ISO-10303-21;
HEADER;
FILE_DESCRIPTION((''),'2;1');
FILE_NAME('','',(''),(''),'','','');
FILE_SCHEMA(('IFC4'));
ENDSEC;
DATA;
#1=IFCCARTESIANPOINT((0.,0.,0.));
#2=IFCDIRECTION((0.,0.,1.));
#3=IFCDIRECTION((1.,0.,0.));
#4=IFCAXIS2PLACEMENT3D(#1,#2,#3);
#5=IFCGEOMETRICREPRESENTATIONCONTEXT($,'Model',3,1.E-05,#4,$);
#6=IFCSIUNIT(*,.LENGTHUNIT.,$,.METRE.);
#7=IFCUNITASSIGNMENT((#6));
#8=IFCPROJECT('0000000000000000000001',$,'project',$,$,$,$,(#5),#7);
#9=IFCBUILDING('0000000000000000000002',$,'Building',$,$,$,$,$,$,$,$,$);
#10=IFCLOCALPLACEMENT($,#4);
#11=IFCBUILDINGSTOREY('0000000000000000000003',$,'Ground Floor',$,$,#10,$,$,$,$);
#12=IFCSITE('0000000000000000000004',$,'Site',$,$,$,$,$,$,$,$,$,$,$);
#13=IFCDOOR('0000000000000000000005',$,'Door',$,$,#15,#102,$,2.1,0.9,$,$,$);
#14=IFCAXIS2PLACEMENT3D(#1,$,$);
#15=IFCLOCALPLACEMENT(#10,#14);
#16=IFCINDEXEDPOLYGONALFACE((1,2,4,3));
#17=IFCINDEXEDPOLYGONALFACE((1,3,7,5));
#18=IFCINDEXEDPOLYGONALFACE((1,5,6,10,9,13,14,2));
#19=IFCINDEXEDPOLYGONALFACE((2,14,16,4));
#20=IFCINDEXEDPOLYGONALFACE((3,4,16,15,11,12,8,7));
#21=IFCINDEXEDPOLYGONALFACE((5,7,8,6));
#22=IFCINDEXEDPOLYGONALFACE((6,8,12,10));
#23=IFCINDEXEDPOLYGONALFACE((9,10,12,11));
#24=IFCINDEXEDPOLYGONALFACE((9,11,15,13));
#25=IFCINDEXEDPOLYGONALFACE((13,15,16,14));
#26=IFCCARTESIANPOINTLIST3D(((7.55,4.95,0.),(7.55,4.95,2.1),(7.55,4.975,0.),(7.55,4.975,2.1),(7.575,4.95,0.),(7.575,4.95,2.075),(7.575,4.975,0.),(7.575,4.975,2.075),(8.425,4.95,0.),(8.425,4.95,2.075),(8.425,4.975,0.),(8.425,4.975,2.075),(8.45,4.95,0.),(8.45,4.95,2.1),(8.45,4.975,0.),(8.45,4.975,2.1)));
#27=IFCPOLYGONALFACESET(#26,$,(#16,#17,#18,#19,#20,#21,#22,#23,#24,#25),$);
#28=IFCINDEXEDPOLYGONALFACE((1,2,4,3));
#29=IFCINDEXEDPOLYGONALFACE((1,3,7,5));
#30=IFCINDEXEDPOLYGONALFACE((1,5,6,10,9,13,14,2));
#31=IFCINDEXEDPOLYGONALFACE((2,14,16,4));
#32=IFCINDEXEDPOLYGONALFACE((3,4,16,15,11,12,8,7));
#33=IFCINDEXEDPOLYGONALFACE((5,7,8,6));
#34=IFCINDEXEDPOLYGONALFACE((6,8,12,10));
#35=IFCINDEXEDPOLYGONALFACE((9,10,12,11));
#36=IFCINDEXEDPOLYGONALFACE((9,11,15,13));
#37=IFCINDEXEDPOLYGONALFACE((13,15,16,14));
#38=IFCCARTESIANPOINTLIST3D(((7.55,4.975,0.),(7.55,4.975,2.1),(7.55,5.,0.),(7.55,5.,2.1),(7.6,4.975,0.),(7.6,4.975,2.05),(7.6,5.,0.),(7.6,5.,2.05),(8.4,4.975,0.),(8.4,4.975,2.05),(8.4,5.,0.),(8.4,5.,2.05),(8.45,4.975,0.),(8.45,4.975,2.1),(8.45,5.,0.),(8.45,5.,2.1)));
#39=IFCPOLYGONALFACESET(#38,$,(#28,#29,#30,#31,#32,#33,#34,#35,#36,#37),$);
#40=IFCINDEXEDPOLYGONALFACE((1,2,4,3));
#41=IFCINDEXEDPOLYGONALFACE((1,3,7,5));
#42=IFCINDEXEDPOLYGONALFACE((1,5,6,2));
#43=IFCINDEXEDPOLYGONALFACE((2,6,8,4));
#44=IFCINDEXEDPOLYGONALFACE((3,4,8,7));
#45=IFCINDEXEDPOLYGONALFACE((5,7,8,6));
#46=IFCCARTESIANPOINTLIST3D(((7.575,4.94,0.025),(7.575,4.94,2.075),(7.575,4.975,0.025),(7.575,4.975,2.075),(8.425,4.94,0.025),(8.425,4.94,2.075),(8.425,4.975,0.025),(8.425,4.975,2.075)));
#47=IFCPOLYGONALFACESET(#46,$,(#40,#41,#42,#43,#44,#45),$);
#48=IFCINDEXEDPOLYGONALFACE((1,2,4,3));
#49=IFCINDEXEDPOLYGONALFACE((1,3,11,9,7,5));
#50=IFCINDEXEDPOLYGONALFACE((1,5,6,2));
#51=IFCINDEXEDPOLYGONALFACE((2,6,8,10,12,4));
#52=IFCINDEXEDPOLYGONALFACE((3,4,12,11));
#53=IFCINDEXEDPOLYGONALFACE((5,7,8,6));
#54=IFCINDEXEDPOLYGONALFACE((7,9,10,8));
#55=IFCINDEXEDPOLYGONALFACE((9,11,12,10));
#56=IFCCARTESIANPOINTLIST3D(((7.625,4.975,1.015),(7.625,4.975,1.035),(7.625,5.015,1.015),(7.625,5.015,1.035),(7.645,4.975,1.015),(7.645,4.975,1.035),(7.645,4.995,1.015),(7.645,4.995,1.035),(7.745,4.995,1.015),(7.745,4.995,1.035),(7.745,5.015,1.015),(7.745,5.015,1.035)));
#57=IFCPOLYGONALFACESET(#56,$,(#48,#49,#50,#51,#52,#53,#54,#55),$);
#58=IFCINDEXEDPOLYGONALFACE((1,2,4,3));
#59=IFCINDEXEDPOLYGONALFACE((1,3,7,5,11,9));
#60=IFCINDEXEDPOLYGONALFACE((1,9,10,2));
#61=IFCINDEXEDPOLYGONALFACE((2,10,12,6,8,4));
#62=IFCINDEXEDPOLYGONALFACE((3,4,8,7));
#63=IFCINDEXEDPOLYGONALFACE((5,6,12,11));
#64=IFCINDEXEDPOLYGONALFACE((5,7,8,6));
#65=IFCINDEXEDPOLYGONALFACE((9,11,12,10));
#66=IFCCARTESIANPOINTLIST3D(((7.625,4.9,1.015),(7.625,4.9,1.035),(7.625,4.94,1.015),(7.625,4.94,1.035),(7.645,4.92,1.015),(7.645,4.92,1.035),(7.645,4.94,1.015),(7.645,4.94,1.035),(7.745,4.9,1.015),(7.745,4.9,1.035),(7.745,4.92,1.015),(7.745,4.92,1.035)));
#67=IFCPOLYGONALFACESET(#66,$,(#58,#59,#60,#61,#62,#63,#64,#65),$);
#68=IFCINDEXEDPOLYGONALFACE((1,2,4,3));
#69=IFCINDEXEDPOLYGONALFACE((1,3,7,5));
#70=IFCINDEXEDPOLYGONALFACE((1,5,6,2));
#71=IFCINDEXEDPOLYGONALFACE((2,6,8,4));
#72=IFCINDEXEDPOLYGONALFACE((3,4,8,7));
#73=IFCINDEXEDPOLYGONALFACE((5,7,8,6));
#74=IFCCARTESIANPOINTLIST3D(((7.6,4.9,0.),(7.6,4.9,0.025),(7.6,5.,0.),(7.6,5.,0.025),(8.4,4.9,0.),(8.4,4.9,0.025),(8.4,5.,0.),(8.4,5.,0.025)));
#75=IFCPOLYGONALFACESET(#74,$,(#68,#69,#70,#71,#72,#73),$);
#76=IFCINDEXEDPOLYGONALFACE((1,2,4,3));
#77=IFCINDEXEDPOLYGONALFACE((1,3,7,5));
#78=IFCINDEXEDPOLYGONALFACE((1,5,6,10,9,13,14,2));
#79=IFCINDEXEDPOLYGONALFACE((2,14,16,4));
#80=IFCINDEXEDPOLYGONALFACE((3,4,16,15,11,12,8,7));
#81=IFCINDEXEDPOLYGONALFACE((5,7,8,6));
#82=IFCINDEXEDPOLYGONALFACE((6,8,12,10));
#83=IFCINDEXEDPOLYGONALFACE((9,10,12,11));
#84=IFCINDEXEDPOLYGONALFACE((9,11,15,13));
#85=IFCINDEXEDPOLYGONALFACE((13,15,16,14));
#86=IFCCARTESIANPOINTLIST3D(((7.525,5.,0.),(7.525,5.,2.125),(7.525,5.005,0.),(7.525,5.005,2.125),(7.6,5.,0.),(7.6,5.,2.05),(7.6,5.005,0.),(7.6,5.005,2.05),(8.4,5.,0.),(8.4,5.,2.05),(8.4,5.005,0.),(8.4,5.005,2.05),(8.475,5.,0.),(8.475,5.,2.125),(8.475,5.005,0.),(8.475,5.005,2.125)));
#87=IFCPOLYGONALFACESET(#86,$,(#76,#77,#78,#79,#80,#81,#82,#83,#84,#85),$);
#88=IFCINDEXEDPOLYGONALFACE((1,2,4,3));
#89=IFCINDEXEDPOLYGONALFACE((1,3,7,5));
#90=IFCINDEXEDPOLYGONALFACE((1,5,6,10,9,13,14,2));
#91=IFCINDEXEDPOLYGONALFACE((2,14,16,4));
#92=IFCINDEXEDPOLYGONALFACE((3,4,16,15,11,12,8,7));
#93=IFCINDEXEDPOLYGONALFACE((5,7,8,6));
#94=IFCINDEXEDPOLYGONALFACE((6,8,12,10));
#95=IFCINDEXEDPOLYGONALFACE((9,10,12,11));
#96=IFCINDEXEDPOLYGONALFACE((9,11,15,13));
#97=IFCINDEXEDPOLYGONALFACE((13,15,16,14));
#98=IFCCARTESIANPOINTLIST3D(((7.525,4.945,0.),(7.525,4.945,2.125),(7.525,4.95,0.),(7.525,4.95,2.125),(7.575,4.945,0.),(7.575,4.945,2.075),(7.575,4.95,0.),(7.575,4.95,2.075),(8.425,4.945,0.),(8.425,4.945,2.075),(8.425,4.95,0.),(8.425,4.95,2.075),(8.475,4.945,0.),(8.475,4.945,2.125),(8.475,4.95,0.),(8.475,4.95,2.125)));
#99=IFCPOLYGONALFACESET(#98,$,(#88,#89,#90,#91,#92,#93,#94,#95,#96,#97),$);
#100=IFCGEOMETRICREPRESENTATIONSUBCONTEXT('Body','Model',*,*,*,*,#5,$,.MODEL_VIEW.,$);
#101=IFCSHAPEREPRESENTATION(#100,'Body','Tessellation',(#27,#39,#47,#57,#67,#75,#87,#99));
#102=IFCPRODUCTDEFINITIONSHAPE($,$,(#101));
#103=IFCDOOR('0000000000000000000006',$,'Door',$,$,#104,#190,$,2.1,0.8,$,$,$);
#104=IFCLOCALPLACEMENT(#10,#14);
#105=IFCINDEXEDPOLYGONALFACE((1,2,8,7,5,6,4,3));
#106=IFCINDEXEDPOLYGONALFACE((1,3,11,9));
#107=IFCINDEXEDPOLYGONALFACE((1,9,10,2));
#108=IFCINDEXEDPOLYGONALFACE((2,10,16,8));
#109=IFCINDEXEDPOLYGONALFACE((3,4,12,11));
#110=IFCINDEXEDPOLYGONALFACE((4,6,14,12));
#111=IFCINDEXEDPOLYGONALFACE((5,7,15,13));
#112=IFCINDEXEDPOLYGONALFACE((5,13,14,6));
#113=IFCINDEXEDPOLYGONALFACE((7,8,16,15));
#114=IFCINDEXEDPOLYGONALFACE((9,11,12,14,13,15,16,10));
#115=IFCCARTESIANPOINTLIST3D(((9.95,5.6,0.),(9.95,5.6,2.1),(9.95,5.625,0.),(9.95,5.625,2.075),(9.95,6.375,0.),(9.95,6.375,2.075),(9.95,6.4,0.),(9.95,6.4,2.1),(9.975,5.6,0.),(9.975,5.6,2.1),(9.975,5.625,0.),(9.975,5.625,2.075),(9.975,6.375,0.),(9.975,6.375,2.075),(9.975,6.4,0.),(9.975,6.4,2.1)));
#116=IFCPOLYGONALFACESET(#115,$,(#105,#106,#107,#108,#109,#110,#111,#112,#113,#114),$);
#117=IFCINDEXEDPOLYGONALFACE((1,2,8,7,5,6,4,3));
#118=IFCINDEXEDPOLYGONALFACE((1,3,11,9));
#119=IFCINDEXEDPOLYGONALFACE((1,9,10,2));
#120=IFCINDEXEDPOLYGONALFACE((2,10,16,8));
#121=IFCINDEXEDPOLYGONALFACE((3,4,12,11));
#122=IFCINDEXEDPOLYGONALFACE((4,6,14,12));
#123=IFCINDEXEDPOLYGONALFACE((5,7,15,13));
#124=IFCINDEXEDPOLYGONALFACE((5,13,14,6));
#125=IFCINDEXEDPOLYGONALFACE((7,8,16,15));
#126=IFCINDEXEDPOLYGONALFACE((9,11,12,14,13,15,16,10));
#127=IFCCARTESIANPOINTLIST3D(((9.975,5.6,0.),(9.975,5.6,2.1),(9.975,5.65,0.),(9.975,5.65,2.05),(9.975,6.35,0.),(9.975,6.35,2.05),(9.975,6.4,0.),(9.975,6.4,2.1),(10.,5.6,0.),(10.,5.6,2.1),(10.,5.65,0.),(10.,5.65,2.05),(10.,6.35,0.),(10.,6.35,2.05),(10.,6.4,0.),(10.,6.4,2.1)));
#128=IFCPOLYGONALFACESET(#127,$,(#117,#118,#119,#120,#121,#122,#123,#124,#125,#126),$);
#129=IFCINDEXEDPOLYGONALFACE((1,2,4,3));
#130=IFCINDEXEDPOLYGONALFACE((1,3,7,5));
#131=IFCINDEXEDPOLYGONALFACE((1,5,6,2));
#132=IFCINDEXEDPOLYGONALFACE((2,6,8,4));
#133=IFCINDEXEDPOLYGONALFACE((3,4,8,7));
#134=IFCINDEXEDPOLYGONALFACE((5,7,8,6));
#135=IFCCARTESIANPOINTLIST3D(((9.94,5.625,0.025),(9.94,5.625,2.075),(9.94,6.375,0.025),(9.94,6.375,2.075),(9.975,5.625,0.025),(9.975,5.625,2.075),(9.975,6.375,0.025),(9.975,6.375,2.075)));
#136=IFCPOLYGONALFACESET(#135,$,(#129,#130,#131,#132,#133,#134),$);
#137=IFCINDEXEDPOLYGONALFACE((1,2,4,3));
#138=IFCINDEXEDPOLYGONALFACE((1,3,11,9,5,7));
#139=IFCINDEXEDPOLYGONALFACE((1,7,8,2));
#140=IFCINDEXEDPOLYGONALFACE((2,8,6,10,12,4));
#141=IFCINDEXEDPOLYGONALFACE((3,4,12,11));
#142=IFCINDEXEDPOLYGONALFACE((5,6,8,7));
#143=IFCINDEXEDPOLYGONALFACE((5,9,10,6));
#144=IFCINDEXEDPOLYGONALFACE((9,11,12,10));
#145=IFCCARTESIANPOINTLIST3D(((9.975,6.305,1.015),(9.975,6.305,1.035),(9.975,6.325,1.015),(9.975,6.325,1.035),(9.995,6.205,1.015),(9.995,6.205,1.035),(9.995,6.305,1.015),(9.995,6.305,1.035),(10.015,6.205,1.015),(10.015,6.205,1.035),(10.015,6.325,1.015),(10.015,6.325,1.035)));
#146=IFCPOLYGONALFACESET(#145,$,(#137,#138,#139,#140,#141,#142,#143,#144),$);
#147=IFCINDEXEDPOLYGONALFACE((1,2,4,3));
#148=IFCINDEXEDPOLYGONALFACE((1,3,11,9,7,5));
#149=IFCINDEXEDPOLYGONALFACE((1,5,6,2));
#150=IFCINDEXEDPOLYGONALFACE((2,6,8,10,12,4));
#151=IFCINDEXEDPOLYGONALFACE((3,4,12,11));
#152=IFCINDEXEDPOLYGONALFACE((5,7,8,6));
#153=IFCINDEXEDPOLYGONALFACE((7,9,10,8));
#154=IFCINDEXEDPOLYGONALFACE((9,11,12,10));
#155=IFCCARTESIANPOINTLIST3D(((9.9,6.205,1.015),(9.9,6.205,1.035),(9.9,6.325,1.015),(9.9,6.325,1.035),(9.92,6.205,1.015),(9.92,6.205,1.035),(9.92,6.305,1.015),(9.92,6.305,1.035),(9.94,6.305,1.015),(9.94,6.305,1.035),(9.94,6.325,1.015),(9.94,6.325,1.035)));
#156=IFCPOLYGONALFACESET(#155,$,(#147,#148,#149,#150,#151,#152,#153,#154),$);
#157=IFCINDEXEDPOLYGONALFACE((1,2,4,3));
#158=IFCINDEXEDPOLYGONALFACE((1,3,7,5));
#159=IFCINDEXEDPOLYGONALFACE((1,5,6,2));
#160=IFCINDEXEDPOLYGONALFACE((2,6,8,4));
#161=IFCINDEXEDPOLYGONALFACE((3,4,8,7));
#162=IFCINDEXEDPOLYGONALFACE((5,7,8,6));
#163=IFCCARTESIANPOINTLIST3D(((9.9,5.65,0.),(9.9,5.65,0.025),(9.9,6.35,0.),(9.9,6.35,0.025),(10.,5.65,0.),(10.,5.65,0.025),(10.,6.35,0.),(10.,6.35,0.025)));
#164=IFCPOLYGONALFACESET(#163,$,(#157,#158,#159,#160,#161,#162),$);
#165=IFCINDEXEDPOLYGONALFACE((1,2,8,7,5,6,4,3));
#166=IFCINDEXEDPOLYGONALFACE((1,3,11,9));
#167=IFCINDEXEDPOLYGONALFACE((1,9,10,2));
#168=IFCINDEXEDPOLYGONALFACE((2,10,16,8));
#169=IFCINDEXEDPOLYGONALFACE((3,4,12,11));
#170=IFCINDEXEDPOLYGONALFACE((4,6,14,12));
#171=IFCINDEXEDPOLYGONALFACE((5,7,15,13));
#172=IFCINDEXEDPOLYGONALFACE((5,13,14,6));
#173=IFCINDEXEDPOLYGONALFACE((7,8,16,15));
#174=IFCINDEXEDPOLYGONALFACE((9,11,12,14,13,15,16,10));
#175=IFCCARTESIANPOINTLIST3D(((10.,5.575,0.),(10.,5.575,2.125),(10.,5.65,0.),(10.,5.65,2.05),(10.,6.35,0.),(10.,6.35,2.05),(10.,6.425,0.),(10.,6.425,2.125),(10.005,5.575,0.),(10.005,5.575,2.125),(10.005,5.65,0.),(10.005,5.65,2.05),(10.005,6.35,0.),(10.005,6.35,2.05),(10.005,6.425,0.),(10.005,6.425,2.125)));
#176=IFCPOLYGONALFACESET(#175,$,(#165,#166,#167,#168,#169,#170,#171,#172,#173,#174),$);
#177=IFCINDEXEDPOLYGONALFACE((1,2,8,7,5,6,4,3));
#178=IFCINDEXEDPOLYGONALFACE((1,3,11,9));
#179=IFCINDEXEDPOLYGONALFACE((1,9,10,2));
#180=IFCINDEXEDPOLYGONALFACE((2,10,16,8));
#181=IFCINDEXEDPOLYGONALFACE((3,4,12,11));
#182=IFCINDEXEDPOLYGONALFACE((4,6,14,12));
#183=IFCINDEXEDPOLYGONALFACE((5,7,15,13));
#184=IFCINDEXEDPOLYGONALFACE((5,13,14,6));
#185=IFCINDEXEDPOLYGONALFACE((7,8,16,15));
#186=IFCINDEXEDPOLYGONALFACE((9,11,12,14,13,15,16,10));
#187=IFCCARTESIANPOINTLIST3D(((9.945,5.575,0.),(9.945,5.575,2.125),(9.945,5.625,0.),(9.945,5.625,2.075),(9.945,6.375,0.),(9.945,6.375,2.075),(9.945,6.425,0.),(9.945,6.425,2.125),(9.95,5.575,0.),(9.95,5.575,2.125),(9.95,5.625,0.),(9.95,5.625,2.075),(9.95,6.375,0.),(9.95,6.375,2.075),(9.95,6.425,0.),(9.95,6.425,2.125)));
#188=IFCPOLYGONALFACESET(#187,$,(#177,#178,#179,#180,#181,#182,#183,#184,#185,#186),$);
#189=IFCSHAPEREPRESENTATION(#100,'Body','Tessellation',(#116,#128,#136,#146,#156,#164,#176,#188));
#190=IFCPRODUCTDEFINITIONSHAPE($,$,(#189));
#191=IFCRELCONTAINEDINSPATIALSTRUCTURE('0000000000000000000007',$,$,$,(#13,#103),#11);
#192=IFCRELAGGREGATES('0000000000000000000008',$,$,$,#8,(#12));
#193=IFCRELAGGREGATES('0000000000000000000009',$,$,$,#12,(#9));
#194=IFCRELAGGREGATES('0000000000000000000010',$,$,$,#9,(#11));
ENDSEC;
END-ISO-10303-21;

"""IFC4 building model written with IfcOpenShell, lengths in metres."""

from ifc_helpers import new_model, si_unit, frame, origin_with_axes, place, context, subcontext, project, spatial, line, indexed_curve, outline, extrude, element, save


model = new_model("IFC4")

# Units and contexts
model_context = context("Model", 3, precision=1e-05, world=origin_with_axes())
body_context = subcontext(model_context, "Body", "Model", "MODEL_VIEW")
ifc_project = project(units=[si_unit("LENGTHUNIT", "METRE")], contexts=[model_context])

# Site, building, storey
site = spatial("IfcSite", under=ifc_project, Name="Site")
building = spatial("IfcBuilding", under=site, Name="Building")
storey_placement = place(None, origin_with_axes())
storey = spatial("IfcBuildingStorey", under=building, at=storey_placement, Name="Ground Floor")

# Doors
door_1_placement = place(storey_placement, frame((8.45, 5.0, 0.0), z_axis=(0.0, 0.0, 1.0), x_axis=(-1.0, 0.0, 0.0)))
element("IfcDoor", 1, at=door_1_placement, inside=storey, Name="Door", OverallHeight=2.1, OverallWidth=0.9, context=body_context, shape_type="SweptSolid", body=[
    extrude(outline(indexed_curve([(0.0, 0.0), (0.0, 2.1), (0.9, 2.1), (0.9, 0.0), (0.875, 0.0), (0.875, 2.075), (0.025, 2.075), (0.025, 0.0)], segments=[line(1, 2, 3, 4, 5, 6, 7, 8, 1)])), frame((0.0, 0.025, 0.0), z_axis=(0.0, -1.0, 0.0), x_axis=(1.0, 0.0, 0.0)), (0.0, 0.0, -1.0), 0.025),
    extrude(outline(indexed_curve([(0.0, 0.0), (0.0, 2.1), (0.9, 2.1), (0.9, 0.0), (0.85, 0.0), (0.85, 2.05), (0.05, 2.05), (0.05, 0.0)], segments=[line(1, 2, 3, 4, 5, 6, 7, 8, 1)])), frame((0.0, 0.0, 0.0), z_axis=(0.0, -1.0, 0.0), x_axis=(1.0, 0.0, 0.0)), (0.0, 0.0, -1.0), 0.025),
    extrude(outline(indexed_curve([(0.0, 0.0), (0.85, 0.0), (0.85, 0.035), (0.0, 0.035)], segments=[line(1, 2, 3, 4, 1)])), frame((0.025, 0.025, 0.025), z_axis=(0.0, 0.0, 1.0), x_axis=(1.0, 0.0, 0.0)), (0.0, 0.0, 1.0), 2.05),
    extrude(outline(indexed_curve([(0.0, 0.0), (0.0, -0.04), (-0.12, -0.04), (-0.12, -0.02), (-0.02, -0.02), (-0.02, 0.0)], segments=[line(1, 2, 3, 4, 5, 6, 1)])), frame((0.825, 0.025, 1.015), z_axis=(0.0, 0.0, 1.0), x_axis=(1.0, 0.0, 0.0)), (0.0, 0.0, 1.0), 0.02),
    extrude(outline(indexed_curve([(0.0, 0.0), (0.0, 0.04), (-0.12, 0.04), (-0.12, 0.02), (-0.02, 0.02), (-0.02, 0.0)], segments=[line(1, 2, 3, 4, 5, 6, 1)])), frame((0.825, 0.06, 1.015), z_axis=(0.0, 0.0, 1.0), x_axis=(1.0, 0.0, 0.0)), (0.0, 0.0, 1.0), 0.02),
    extrude(outline(indexed_curve([(0.0, 0.0), (0.8, 0.0), (0.8, 0.1), (0.0, 0.1)], segments=[line(1, 2, 3, 4, 1)])), frame((0.05, 0.0, 0.0), z_axis=(0.0, 0.0, 1.0), x_axis=(1.0, 0.0, 0.0)), (0.0, 0.0, 1.0), 0.025),
    extrude(outline(indexed_curve([(0.0, 0.0), (0.0, 2.125), (0.95, 2.125), (0.95, 0.0), (0.875, 0.0), (0.875, 2.05), (0.075, 2.05), (0.075, 0.0)], segments=[line(1, 2, 3, 4, 5, 6, 7, 8, 1)])), frame((-0.025, -0.005, 0.0), z_axis=(0.0, -1.0, 0.0), x_axis=(1.0, 0.0, 0.0)), (0.0, 0.0, -1.0), 0.005),
    extrude(outline(indexed_curve([(0.0, 0.0), (0.0, 2.125), (0.95, 2.125), (0.95, 0.0), (0.9, 0.0), (0.9, 2.075), (0.05, 2.075), (0.05, 0.0)], segments=[line(1, 2, 3, 4, 5, 6, 7, 8, 1)])), frame((-0.025, 0.05, 0.0), z_axis=(0.0, -1.0, 0.0), x_axis=(1.0, 0.0, 0.0)), (0.0, 0.0, -1.0), 0.005),
])
door_2_placement = place(storey_placement, frame((10.0, 5.6, 0.0), z_axis=(0.0, 0.0, 1.0), x_axis=(0.0, 1.0, 0.0)))
element("IfcDoor", 2, at=door_2_placement, inside=storey, Name="Door", OverallHeight=2.1, OverallWidth=0.8, context=body_context, shape_type="SweptSolid", body=[
    extrude(outline(indexed_curve([(0.0, 0.0), (0.0, 2.1), (0.8, 2.1), (0.8, 0.0), (0.775, 0.0), (0.775, 2.075), (0.025, 2.075), (0.025, 0.0)], segments=[line(1, 2, 3, 4, 5, 6, 7, 8, 1)])), frame((0.0, 0.025, 0.0), z_axis=(0.0, -1.0, 0.0), x_axis=(1.0, 0.0, 0.0)), (0.0, 0.0, -1.0), 0.025),
    extrude(outline(indexed_curve([(0.0, 0.0), (0.0, 2.1), (0.8, 2.1), (0.8, 0.0), (0.75, 0.0), (0.75, 2.05), (0.05, 2.05), (0.05, 0.0)], segments=[line(1, 2, 3, 4, 5, 6, 7, 8, 1)])), frame((0.0, 0.0, 0.0), z_axis=(0.0, -1.0, 0.0), x_axis=(1.0, 0.0, 0.0)), (0.0, 0.0, -1.0), 0.025),
    extrude(outline(indexed_curve([(0.0, 0.0), (0.75, 0.0), (0.75, 0.035), (0.0, 0.035)], segments=[line(1, 2, 3, 4, 1)])), frame((0.025, 0.025, 0.025), z_axis=(0.0, 0.0, 1.0), x_axis=(1.0, 0.0, 0.0)), (0.0, 0.0, 1.0), 2.05),
    extrude(outline(indexed_curve([(0.0, 0.0), (0.0, -0.04), (-0.12, -0.04), (-0.12, -0.02), (-0.02, -0.02), (-0.02, 0.0)], segments=[line(1, 2, 3, 4, 5, 6, 1)])), frame((0.725, 0.025, 1.015), z_axis=(0.0, 0.0, 1.0), x_axis=(1.0, 0.0, 0.0)), (0.0, 0.0, 1.0), 0.02),
    extrude(outline(indexed_curve([(0.0, 0.0), (0.0, 0.04), (-0.12, 0.04), (-0.12, 0.02), (-0.02, 0.02), (-0.02, 0.0)], segments=[line(1, 2, 3, 4, 5, 6, 1)])), frame((0.725, 0.06, 1.015), z_axis=(0.0, 0.0, 1.0), x_axis=(1.0, 0.0, 0.0)), (0.0, 0.0, 1.0), 0.02),
    extrude(outline(indexed_curve([(0.0, 0.0), (0.7, 0.0), (0.7, 0.1), (0.0, 0.1)], segments=[line(1, 2, 3, 4, 1)])), frame((0.05, 0.0, 0.0), z_axis=(0.0, 0.0, 1.0), x_axis=(1.0, 0.0, 0.0)), (0.0, 0.0, 1.0), 0.025),
    extrude(outline(indexed_curve([(0.0, 0.0), (0.0, 2.125), (0.85, 2.125), (0.85, 0.0), (0.775, 0.0), (0.775, 2.05), (0.075, 2.05), (0.075, 0.0)], segments=[line(1, 2, 3, 4, 5, 6, 7, 8, 1)])), frame((-0.025, -0.005, 0.0), z_axis=(0.0, -1.0, 0.0), x_axis=(1.0, 0.0, 0.0)), (0.0, 0.0, -1.0), 0.005),
    extrude(outline(indexed_curve([(0.0, 0.0), (0.0, 2.125), (0.85, 2.125), (0.85, 0.0), (0.8, 0.0), (0.8, 2.075), (0.05, 2.075), (0.05, 0.0)], segments=[line(1, 2, 3, 4, 5, 6, 7, 8, 1)])), frame((-0.025, 0.05, 0.0), z_axis=(0.0, -1.0, 0.0), x_axis=(1.0, 0.0, 0.0)), (0.0, 0.0, -1.0), 0.005),
])

save(model, "model.ifc")
